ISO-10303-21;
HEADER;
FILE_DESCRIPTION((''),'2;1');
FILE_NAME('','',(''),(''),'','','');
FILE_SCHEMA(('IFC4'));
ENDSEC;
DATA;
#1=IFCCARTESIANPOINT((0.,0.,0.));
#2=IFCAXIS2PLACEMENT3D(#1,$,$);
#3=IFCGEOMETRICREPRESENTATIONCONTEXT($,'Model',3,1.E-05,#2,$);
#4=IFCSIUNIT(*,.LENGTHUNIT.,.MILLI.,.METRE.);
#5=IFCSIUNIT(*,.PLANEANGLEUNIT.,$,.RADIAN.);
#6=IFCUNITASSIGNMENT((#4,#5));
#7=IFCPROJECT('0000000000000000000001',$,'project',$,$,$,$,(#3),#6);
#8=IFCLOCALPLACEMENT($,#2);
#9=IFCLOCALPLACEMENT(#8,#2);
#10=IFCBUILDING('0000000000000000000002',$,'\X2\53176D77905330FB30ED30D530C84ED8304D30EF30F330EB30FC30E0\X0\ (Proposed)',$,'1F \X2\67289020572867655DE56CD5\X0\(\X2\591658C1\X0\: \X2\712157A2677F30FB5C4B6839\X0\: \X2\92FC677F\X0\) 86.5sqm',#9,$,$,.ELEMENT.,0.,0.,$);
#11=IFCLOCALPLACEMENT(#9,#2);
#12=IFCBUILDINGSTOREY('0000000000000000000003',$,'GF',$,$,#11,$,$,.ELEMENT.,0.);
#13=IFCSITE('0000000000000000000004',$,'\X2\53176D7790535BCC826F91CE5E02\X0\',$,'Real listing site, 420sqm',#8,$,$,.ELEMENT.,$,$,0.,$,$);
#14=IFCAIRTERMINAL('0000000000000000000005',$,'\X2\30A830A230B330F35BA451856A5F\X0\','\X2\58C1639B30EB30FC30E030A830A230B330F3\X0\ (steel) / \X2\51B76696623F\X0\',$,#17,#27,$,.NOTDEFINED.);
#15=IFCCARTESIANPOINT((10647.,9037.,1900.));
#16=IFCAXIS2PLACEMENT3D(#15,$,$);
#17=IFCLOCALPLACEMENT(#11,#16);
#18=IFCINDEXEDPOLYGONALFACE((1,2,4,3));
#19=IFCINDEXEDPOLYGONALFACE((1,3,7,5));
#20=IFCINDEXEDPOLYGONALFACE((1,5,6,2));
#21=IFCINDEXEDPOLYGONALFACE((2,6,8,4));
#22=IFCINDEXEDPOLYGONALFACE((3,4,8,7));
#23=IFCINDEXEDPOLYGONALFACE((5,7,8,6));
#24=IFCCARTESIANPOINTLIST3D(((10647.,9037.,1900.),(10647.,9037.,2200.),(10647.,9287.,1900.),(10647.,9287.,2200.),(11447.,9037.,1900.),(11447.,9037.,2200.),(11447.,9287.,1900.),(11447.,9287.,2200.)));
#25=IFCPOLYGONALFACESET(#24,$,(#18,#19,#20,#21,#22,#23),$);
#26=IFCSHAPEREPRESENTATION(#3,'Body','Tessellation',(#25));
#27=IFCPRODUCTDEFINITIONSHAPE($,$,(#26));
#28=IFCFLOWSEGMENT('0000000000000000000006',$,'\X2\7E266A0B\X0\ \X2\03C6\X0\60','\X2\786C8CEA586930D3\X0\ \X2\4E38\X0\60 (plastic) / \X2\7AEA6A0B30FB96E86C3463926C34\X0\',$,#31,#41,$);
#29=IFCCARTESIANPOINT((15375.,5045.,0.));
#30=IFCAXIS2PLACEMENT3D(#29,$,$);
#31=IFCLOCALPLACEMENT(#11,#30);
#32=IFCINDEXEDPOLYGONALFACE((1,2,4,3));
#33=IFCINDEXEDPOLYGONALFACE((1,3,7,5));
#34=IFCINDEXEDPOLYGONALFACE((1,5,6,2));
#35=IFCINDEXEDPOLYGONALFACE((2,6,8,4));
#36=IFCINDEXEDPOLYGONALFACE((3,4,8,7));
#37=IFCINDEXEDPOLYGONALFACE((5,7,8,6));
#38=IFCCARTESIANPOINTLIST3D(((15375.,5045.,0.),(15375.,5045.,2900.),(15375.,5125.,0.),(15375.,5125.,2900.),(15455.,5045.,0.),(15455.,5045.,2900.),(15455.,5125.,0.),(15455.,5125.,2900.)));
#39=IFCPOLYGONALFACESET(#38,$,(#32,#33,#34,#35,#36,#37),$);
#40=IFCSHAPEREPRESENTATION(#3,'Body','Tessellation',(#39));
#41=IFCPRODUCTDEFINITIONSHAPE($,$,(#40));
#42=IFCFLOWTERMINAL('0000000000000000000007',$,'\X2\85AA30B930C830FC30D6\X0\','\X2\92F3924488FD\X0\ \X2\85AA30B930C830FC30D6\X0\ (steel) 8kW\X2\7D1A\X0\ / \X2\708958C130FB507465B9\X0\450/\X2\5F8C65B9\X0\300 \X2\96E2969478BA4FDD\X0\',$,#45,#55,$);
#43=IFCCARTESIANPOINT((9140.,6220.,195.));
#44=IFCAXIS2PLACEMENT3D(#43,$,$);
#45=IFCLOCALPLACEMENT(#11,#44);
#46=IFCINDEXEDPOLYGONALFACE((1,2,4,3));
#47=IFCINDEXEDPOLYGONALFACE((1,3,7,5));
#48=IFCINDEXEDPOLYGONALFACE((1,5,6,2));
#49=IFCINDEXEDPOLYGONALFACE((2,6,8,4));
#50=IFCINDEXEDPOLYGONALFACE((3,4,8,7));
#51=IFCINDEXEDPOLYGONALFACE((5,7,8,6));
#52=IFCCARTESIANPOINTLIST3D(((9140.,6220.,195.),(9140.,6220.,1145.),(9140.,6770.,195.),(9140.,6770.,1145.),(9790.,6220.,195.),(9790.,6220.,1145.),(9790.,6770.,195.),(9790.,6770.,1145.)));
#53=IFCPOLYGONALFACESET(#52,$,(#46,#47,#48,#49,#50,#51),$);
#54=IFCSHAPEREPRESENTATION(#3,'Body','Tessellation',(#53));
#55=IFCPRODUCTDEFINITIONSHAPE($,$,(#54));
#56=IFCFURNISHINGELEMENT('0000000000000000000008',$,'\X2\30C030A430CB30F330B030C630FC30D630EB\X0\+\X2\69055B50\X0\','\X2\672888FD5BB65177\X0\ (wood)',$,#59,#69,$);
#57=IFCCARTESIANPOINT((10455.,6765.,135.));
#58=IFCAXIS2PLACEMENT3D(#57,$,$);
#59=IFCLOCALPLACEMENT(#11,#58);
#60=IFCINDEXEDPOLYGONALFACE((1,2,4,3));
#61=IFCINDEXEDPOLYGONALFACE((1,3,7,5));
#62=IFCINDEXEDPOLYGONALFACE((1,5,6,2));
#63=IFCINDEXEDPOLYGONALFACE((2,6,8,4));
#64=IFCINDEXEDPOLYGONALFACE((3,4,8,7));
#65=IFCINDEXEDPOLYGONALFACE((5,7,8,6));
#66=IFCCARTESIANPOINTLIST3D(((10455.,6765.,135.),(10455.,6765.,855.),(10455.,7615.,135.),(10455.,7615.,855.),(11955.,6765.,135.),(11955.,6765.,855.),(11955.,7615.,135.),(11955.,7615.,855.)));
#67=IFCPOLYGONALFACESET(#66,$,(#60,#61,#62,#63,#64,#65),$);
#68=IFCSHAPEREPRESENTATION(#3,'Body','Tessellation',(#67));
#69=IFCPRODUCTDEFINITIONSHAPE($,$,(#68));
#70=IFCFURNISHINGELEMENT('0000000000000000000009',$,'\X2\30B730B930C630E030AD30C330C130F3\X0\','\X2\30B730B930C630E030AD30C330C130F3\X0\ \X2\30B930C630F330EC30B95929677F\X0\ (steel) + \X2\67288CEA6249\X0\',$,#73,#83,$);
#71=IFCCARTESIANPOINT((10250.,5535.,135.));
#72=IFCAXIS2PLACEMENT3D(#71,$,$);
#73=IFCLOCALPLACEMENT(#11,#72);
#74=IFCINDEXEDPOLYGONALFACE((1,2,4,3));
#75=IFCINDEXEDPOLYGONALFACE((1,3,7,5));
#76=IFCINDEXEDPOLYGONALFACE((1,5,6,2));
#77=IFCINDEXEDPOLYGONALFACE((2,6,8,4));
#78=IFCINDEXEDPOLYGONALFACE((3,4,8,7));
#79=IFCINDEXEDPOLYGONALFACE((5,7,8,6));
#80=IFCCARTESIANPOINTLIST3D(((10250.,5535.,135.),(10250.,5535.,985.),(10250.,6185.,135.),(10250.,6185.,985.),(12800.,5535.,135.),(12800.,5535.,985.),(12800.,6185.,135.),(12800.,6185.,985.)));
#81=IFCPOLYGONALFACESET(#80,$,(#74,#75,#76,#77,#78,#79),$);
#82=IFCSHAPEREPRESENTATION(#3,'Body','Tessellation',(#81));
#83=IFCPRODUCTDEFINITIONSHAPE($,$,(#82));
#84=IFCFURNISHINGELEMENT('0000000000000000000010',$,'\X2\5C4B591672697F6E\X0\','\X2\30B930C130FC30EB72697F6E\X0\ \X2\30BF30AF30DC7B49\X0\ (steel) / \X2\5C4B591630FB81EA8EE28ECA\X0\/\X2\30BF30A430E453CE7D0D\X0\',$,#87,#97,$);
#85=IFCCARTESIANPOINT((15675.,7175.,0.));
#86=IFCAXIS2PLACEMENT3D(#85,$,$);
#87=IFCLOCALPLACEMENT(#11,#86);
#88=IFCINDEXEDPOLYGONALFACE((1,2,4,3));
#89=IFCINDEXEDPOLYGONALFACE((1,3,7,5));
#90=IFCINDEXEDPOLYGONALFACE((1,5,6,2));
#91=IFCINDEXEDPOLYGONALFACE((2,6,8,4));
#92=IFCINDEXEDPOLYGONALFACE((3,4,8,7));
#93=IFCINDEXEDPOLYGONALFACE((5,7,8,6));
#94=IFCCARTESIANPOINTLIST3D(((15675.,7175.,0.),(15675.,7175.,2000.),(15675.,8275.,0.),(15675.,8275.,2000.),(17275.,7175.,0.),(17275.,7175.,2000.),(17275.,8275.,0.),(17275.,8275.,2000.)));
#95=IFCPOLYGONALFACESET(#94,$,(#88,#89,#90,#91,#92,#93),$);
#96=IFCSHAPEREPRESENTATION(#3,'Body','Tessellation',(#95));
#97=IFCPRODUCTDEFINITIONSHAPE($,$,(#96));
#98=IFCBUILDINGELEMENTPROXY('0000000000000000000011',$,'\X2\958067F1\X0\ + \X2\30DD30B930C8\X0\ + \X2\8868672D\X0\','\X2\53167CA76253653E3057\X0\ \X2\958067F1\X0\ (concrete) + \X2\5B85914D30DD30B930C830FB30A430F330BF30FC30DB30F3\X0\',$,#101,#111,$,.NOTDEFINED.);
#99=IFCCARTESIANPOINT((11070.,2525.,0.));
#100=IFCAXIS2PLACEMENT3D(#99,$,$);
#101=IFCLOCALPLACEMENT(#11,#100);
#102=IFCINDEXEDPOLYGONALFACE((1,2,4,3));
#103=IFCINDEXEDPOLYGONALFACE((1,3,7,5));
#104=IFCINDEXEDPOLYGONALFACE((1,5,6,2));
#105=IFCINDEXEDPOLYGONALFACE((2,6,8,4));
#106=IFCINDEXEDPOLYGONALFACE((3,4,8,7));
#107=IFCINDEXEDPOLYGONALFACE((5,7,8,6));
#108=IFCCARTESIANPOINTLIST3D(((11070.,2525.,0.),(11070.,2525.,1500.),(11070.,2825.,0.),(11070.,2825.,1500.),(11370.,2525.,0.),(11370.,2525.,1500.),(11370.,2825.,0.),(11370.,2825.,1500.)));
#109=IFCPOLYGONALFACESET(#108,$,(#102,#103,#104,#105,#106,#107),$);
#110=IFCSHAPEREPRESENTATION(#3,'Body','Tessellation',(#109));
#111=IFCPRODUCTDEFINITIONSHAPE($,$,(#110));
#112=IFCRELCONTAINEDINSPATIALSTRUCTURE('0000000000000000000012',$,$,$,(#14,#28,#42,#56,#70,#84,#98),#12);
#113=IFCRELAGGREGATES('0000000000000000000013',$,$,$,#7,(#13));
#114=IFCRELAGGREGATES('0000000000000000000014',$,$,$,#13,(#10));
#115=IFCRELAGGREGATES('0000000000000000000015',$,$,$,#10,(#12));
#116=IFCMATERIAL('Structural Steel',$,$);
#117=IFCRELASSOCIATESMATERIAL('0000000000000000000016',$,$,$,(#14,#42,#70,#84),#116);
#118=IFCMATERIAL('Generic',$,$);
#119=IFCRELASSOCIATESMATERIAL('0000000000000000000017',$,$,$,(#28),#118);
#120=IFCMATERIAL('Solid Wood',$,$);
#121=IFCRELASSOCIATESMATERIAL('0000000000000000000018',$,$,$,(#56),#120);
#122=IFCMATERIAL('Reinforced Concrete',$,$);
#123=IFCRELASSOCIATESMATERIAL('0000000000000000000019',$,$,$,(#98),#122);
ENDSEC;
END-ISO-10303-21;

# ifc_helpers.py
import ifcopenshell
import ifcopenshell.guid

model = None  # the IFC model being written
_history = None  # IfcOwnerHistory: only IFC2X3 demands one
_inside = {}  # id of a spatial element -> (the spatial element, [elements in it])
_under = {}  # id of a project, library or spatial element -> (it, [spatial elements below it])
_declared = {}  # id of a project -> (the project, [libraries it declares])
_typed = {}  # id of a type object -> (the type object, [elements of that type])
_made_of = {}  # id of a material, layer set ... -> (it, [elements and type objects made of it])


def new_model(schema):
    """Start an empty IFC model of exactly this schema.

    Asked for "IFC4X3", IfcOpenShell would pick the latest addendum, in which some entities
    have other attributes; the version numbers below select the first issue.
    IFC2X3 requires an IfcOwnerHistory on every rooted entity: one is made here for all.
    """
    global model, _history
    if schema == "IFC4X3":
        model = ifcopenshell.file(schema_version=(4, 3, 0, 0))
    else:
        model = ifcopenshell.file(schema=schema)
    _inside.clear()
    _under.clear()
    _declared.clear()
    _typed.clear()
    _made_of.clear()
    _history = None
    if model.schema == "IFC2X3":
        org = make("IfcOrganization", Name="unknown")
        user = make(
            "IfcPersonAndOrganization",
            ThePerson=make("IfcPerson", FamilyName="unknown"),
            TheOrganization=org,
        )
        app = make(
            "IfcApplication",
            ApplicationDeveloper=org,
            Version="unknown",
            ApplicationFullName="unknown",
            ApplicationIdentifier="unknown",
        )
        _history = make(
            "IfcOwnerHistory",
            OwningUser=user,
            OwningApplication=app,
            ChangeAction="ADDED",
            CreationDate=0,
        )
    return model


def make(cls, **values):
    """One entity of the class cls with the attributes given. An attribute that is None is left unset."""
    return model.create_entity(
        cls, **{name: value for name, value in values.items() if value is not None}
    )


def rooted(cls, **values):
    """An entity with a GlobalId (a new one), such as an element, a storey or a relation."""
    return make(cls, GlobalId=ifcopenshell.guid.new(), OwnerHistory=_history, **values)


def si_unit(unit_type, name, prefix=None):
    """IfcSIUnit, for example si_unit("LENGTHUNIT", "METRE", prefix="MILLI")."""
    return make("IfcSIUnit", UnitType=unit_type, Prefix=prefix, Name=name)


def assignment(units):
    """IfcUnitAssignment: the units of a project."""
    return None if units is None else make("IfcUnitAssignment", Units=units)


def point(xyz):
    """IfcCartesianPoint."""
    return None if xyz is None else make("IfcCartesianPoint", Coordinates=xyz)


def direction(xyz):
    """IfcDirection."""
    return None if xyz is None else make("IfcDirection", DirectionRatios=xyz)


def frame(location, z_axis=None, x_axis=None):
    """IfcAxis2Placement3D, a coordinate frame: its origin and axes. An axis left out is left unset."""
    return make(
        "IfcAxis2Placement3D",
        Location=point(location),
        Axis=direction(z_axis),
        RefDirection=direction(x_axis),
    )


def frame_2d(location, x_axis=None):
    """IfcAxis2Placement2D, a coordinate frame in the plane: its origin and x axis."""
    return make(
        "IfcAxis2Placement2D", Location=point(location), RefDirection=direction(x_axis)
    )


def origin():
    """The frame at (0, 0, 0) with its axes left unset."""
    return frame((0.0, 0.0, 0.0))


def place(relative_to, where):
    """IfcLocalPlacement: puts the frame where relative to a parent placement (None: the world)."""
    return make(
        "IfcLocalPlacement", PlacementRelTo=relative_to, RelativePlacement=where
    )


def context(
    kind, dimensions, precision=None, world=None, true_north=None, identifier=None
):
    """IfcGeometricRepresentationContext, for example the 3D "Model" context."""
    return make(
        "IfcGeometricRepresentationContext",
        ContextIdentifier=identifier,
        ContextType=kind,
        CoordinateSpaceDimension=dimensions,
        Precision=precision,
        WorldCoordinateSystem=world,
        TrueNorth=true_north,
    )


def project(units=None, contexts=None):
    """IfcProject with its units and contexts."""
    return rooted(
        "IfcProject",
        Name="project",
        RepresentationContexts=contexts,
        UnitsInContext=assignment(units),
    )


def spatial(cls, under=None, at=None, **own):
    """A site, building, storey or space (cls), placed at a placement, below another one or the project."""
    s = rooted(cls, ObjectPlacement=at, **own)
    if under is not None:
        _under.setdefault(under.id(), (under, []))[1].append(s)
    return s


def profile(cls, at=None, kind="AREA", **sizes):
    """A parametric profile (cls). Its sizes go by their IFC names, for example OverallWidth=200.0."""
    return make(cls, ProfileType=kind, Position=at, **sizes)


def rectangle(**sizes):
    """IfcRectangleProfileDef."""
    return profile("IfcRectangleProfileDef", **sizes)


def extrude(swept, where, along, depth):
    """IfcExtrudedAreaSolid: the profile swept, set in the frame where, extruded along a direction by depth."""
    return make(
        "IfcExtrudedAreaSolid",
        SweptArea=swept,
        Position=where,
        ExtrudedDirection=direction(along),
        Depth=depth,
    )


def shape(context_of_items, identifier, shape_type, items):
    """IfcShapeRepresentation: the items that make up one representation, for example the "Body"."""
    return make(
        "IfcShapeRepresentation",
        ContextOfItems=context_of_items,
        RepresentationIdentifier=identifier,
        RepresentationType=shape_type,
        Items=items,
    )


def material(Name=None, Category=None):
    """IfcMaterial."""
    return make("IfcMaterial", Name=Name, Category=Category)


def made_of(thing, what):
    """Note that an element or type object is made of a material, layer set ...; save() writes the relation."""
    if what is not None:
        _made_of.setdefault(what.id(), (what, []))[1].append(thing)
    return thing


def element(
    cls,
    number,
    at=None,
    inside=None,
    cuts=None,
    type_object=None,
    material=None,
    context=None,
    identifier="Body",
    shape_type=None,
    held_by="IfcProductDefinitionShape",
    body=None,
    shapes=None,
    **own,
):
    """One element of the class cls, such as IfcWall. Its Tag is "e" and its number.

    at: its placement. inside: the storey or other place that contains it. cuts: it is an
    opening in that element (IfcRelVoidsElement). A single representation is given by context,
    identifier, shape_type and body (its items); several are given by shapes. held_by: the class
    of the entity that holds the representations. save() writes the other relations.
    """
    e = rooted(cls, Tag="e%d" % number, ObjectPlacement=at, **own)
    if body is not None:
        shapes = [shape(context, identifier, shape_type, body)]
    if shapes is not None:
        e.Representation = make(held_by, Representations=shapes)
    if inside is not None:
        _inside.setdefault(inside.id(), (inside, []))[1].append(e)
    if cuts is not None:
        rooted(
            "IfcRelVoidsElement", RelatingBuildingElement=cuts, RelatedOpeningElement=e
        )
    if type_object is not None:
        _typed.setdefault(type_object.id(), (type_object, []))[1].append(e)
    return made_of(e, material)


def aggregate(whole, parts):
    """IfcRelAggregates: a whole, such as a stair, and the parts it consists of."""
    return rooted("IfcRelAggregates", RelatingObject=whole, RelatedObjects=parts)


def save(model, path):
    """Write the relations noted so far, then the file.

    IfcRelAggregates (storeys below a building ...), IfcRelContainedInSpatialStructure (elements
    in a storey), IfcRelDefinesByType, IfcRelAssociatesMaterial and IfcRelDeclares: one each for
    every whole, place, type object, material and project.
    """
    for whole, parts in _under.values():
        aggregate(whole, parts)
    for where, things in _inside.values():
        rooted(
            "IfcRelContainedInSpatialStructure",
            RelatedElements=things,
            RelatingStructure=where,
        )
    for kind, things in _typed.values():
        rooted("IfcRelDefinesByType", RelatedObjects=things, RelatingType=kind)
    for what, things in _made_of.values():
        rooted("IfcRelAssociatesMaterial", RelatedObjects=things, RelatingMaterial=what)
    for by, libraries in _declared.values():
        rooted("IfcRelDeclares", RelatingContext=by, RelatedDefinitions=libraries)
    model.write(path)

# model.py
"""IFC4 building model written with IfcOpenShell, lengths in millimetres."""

from ifc_helpers import new_model, si_unit, frame, frame_2d, origin, place, context, project, spatial, rectangle, extrude, material, element, save


model = new_model("IFC4")

# Units and contexts
model_context = context("Model", 3, precision=1e-05, world=origin())
ifc_project = project(units=[si_unit("LENGTHUNIT", "METRE", prefix="MILLI"), si_unit("PLANEANGLEUNIT", "RADIAN")], contexts=[model_context])

# Site, building, storey
site_placement = place(None, origin())
site = spatial("IfcSite", under=ifc_project, at=site_placement, Name="北海道富良野市", ObjectType="Real listing site, 420sqm", CompositionType="ELEMENT", RefElevation=0.0)
building_placement = place(site_placement, origin())
building = spatial("IfcBuilding", under=site, at=building_placement, Name="北海道・ロフト付きワンルーム (Proposed)", ObjectType="1F 木造在来工法(外壁: 無垢板・屋根: 鋼板) 86.5sqm", CompositionType="ELEMENT", ElevationOfRefHeight=0.0, ElevationOfTerrain=0.0)
storey_placement = place(building_placement, origin())
storey = spatial("IfcBuildingStorey", under=building, at=storey_placement, Name="GF", CompositionType="ELEMENT", Elevation=0.0)

# Shared definitions
ifc_material_1 = material(Name="Solid Wood")

# Shared definitions
ifc_material_2 = material(Name="Structural Steel")

# Shared definitions
ifc_material_3 = material(Name="Reinforced Concrete")

# Shared definitions
ifc_material_4 = material(Name="Generic")

# Air terminal
air_terminal_placement = place(storey_placement, frame((10647.0, 9037.0, 1900.0)))
element("IfcAirTerminal", 1, at=air_terminal_placement, inside=storey, material=ifc_material_2, Name="エアコン室内機", Description="壁掛ルームエアコン (steel) / 冷暖房", PredefinedType="NOTDEFINED", context=model_context, shape_type="SweptSolid", body=[
    extrude(rectangle(XDim=800.0, YDim=250.0, at=frame_2d((400.0, 125.0))), frame((10647.0, 9037.0, 1900.0)), (0.0, 0.0, 1.0), 300.0),
])

# Flow segment
flow_segment_placement = place(storey_placement, frame((15375.0, 5045.0, 0.0)))
element("IfcFlowSegment", 2, at=flow_segment_placement, inside=storey, material=ifc_material_4, Name="縦樋 φ60", Description="硬質塩ビ 丸60 (plastic) / 竪樋・雨水排水", context=model_context, shape_type="SweptSolid", body=[
    extrude(rectangle(XDim=80.0, YDim=80.0, at=frame_2d((40.0, 40.0))), frame((15375.0, 5045.0, 0.0)), (0.0, 0.0, 1.0), 2900.0),
])

# Flow terminal
flow_terminal_1_placement = place(storey_placement, frame((9140.0, 6220.0, 195.0)))
element("IfcFlowTerminal", 3, at=flow_terminal_1_placement, inside=storey, material=ifc_material_2, Name="薪ストーブ", Description="鋳鉄製 薪ストーブ (steel) 8kW級 / 炉壁・側方450/後方300 離隔確保", context=model_context, shape_type="SweptSolid", body=[
    extrude(rectangle(XDim=650.0, YDim=550.0, at=frame_2d((325.0, 275.0))), frame((9140.0, 6220.0, 195.0)), (0.0, 0.0, 1.0), 950.0),
])

# Furnishing elements
furnishing_1_placement = place(storey_placement, frame((10455.0, 6765.0, 135.0)))
element("IfcFurnishingElement", 4, at=furnishing_1_placement, inside=storey, material=ifc_material_1, Name="ダイニングテーブル+椅子", Description="木製家具 (wood)", context=model_context, shape_type="SweptSolid", body=[
    extrude(rectangle(XDim=1500.0, YDim=850.0, at=frame_2d((750.0, 425.0))), frame((10455.0, 6765.0, 135.0)), (0.0, 0.0, 1.0), 720.0),
])
furnishing_2_placement = place(storey_placement, frame((10250.0, 5535.0, 135.0)))
element("IfcFurnishingElement", 5, at=furnishing_2_placement, inside=storey, material=ifc_material_2, Name="システムキッチン", Description="システムキッチン ステンレス天板 (steel) + 木質扉", context=model_context, shape_type="SweptSolid", body=[
    extrude(rectangle(XDim=2550.0, YDim=650.0, at=frame_2d((1275.0, 325.0))), frame((10250.0, 5535.0, 135.0)), (0.0, 0.0, 1.0), 850.0),
])
furnishing_3_placement = place(storey_placement, frame((15675.0, 7175.0, 0.0)))
element("IfcFurnishingElement", 6, at=furnishing_3_placement, inside=storey, material=ifc_material_2, Name="屋外物置", Description="スチール物置 タクボ等 (steel) / 屋外・自転車/タイヤ収納", context=model_context, shape_type="SweptSolid", body=[
    extrude(rectangle(XDim=1600.0, YDim=1100.0, at=frame_2d((800.0, 550.0))), frame((15675.0, 7175.0, 0.0)), (0.0, 0.0, 1.0), 2000.0),
])

# Building element proxy
proxy_placement = place(storey_placement, frame((11070.0, 2525.0, 0.0)))
element("IfcBuildingElementProxy", 7, at=proxy_placement, inside=storey, material=ifc_material_3, Name="門柱 + ポスト + 表札", Description="化粧打放し 門柱 (concrete) + 宅配ポスト・インターホン", PredefinedType="NOTDEFINED", context=model_context, shape_type="SweptSolid", body=[
    extrude(rectangle(XDim=300.0, YDim=300.0, at=frame_2d((150.0, 150.0))), frame((11070.0, 2525.0, 0.0)), (0.0, 0.0, 1.0), 1500.0),
])

save(model, "model.ifc")
